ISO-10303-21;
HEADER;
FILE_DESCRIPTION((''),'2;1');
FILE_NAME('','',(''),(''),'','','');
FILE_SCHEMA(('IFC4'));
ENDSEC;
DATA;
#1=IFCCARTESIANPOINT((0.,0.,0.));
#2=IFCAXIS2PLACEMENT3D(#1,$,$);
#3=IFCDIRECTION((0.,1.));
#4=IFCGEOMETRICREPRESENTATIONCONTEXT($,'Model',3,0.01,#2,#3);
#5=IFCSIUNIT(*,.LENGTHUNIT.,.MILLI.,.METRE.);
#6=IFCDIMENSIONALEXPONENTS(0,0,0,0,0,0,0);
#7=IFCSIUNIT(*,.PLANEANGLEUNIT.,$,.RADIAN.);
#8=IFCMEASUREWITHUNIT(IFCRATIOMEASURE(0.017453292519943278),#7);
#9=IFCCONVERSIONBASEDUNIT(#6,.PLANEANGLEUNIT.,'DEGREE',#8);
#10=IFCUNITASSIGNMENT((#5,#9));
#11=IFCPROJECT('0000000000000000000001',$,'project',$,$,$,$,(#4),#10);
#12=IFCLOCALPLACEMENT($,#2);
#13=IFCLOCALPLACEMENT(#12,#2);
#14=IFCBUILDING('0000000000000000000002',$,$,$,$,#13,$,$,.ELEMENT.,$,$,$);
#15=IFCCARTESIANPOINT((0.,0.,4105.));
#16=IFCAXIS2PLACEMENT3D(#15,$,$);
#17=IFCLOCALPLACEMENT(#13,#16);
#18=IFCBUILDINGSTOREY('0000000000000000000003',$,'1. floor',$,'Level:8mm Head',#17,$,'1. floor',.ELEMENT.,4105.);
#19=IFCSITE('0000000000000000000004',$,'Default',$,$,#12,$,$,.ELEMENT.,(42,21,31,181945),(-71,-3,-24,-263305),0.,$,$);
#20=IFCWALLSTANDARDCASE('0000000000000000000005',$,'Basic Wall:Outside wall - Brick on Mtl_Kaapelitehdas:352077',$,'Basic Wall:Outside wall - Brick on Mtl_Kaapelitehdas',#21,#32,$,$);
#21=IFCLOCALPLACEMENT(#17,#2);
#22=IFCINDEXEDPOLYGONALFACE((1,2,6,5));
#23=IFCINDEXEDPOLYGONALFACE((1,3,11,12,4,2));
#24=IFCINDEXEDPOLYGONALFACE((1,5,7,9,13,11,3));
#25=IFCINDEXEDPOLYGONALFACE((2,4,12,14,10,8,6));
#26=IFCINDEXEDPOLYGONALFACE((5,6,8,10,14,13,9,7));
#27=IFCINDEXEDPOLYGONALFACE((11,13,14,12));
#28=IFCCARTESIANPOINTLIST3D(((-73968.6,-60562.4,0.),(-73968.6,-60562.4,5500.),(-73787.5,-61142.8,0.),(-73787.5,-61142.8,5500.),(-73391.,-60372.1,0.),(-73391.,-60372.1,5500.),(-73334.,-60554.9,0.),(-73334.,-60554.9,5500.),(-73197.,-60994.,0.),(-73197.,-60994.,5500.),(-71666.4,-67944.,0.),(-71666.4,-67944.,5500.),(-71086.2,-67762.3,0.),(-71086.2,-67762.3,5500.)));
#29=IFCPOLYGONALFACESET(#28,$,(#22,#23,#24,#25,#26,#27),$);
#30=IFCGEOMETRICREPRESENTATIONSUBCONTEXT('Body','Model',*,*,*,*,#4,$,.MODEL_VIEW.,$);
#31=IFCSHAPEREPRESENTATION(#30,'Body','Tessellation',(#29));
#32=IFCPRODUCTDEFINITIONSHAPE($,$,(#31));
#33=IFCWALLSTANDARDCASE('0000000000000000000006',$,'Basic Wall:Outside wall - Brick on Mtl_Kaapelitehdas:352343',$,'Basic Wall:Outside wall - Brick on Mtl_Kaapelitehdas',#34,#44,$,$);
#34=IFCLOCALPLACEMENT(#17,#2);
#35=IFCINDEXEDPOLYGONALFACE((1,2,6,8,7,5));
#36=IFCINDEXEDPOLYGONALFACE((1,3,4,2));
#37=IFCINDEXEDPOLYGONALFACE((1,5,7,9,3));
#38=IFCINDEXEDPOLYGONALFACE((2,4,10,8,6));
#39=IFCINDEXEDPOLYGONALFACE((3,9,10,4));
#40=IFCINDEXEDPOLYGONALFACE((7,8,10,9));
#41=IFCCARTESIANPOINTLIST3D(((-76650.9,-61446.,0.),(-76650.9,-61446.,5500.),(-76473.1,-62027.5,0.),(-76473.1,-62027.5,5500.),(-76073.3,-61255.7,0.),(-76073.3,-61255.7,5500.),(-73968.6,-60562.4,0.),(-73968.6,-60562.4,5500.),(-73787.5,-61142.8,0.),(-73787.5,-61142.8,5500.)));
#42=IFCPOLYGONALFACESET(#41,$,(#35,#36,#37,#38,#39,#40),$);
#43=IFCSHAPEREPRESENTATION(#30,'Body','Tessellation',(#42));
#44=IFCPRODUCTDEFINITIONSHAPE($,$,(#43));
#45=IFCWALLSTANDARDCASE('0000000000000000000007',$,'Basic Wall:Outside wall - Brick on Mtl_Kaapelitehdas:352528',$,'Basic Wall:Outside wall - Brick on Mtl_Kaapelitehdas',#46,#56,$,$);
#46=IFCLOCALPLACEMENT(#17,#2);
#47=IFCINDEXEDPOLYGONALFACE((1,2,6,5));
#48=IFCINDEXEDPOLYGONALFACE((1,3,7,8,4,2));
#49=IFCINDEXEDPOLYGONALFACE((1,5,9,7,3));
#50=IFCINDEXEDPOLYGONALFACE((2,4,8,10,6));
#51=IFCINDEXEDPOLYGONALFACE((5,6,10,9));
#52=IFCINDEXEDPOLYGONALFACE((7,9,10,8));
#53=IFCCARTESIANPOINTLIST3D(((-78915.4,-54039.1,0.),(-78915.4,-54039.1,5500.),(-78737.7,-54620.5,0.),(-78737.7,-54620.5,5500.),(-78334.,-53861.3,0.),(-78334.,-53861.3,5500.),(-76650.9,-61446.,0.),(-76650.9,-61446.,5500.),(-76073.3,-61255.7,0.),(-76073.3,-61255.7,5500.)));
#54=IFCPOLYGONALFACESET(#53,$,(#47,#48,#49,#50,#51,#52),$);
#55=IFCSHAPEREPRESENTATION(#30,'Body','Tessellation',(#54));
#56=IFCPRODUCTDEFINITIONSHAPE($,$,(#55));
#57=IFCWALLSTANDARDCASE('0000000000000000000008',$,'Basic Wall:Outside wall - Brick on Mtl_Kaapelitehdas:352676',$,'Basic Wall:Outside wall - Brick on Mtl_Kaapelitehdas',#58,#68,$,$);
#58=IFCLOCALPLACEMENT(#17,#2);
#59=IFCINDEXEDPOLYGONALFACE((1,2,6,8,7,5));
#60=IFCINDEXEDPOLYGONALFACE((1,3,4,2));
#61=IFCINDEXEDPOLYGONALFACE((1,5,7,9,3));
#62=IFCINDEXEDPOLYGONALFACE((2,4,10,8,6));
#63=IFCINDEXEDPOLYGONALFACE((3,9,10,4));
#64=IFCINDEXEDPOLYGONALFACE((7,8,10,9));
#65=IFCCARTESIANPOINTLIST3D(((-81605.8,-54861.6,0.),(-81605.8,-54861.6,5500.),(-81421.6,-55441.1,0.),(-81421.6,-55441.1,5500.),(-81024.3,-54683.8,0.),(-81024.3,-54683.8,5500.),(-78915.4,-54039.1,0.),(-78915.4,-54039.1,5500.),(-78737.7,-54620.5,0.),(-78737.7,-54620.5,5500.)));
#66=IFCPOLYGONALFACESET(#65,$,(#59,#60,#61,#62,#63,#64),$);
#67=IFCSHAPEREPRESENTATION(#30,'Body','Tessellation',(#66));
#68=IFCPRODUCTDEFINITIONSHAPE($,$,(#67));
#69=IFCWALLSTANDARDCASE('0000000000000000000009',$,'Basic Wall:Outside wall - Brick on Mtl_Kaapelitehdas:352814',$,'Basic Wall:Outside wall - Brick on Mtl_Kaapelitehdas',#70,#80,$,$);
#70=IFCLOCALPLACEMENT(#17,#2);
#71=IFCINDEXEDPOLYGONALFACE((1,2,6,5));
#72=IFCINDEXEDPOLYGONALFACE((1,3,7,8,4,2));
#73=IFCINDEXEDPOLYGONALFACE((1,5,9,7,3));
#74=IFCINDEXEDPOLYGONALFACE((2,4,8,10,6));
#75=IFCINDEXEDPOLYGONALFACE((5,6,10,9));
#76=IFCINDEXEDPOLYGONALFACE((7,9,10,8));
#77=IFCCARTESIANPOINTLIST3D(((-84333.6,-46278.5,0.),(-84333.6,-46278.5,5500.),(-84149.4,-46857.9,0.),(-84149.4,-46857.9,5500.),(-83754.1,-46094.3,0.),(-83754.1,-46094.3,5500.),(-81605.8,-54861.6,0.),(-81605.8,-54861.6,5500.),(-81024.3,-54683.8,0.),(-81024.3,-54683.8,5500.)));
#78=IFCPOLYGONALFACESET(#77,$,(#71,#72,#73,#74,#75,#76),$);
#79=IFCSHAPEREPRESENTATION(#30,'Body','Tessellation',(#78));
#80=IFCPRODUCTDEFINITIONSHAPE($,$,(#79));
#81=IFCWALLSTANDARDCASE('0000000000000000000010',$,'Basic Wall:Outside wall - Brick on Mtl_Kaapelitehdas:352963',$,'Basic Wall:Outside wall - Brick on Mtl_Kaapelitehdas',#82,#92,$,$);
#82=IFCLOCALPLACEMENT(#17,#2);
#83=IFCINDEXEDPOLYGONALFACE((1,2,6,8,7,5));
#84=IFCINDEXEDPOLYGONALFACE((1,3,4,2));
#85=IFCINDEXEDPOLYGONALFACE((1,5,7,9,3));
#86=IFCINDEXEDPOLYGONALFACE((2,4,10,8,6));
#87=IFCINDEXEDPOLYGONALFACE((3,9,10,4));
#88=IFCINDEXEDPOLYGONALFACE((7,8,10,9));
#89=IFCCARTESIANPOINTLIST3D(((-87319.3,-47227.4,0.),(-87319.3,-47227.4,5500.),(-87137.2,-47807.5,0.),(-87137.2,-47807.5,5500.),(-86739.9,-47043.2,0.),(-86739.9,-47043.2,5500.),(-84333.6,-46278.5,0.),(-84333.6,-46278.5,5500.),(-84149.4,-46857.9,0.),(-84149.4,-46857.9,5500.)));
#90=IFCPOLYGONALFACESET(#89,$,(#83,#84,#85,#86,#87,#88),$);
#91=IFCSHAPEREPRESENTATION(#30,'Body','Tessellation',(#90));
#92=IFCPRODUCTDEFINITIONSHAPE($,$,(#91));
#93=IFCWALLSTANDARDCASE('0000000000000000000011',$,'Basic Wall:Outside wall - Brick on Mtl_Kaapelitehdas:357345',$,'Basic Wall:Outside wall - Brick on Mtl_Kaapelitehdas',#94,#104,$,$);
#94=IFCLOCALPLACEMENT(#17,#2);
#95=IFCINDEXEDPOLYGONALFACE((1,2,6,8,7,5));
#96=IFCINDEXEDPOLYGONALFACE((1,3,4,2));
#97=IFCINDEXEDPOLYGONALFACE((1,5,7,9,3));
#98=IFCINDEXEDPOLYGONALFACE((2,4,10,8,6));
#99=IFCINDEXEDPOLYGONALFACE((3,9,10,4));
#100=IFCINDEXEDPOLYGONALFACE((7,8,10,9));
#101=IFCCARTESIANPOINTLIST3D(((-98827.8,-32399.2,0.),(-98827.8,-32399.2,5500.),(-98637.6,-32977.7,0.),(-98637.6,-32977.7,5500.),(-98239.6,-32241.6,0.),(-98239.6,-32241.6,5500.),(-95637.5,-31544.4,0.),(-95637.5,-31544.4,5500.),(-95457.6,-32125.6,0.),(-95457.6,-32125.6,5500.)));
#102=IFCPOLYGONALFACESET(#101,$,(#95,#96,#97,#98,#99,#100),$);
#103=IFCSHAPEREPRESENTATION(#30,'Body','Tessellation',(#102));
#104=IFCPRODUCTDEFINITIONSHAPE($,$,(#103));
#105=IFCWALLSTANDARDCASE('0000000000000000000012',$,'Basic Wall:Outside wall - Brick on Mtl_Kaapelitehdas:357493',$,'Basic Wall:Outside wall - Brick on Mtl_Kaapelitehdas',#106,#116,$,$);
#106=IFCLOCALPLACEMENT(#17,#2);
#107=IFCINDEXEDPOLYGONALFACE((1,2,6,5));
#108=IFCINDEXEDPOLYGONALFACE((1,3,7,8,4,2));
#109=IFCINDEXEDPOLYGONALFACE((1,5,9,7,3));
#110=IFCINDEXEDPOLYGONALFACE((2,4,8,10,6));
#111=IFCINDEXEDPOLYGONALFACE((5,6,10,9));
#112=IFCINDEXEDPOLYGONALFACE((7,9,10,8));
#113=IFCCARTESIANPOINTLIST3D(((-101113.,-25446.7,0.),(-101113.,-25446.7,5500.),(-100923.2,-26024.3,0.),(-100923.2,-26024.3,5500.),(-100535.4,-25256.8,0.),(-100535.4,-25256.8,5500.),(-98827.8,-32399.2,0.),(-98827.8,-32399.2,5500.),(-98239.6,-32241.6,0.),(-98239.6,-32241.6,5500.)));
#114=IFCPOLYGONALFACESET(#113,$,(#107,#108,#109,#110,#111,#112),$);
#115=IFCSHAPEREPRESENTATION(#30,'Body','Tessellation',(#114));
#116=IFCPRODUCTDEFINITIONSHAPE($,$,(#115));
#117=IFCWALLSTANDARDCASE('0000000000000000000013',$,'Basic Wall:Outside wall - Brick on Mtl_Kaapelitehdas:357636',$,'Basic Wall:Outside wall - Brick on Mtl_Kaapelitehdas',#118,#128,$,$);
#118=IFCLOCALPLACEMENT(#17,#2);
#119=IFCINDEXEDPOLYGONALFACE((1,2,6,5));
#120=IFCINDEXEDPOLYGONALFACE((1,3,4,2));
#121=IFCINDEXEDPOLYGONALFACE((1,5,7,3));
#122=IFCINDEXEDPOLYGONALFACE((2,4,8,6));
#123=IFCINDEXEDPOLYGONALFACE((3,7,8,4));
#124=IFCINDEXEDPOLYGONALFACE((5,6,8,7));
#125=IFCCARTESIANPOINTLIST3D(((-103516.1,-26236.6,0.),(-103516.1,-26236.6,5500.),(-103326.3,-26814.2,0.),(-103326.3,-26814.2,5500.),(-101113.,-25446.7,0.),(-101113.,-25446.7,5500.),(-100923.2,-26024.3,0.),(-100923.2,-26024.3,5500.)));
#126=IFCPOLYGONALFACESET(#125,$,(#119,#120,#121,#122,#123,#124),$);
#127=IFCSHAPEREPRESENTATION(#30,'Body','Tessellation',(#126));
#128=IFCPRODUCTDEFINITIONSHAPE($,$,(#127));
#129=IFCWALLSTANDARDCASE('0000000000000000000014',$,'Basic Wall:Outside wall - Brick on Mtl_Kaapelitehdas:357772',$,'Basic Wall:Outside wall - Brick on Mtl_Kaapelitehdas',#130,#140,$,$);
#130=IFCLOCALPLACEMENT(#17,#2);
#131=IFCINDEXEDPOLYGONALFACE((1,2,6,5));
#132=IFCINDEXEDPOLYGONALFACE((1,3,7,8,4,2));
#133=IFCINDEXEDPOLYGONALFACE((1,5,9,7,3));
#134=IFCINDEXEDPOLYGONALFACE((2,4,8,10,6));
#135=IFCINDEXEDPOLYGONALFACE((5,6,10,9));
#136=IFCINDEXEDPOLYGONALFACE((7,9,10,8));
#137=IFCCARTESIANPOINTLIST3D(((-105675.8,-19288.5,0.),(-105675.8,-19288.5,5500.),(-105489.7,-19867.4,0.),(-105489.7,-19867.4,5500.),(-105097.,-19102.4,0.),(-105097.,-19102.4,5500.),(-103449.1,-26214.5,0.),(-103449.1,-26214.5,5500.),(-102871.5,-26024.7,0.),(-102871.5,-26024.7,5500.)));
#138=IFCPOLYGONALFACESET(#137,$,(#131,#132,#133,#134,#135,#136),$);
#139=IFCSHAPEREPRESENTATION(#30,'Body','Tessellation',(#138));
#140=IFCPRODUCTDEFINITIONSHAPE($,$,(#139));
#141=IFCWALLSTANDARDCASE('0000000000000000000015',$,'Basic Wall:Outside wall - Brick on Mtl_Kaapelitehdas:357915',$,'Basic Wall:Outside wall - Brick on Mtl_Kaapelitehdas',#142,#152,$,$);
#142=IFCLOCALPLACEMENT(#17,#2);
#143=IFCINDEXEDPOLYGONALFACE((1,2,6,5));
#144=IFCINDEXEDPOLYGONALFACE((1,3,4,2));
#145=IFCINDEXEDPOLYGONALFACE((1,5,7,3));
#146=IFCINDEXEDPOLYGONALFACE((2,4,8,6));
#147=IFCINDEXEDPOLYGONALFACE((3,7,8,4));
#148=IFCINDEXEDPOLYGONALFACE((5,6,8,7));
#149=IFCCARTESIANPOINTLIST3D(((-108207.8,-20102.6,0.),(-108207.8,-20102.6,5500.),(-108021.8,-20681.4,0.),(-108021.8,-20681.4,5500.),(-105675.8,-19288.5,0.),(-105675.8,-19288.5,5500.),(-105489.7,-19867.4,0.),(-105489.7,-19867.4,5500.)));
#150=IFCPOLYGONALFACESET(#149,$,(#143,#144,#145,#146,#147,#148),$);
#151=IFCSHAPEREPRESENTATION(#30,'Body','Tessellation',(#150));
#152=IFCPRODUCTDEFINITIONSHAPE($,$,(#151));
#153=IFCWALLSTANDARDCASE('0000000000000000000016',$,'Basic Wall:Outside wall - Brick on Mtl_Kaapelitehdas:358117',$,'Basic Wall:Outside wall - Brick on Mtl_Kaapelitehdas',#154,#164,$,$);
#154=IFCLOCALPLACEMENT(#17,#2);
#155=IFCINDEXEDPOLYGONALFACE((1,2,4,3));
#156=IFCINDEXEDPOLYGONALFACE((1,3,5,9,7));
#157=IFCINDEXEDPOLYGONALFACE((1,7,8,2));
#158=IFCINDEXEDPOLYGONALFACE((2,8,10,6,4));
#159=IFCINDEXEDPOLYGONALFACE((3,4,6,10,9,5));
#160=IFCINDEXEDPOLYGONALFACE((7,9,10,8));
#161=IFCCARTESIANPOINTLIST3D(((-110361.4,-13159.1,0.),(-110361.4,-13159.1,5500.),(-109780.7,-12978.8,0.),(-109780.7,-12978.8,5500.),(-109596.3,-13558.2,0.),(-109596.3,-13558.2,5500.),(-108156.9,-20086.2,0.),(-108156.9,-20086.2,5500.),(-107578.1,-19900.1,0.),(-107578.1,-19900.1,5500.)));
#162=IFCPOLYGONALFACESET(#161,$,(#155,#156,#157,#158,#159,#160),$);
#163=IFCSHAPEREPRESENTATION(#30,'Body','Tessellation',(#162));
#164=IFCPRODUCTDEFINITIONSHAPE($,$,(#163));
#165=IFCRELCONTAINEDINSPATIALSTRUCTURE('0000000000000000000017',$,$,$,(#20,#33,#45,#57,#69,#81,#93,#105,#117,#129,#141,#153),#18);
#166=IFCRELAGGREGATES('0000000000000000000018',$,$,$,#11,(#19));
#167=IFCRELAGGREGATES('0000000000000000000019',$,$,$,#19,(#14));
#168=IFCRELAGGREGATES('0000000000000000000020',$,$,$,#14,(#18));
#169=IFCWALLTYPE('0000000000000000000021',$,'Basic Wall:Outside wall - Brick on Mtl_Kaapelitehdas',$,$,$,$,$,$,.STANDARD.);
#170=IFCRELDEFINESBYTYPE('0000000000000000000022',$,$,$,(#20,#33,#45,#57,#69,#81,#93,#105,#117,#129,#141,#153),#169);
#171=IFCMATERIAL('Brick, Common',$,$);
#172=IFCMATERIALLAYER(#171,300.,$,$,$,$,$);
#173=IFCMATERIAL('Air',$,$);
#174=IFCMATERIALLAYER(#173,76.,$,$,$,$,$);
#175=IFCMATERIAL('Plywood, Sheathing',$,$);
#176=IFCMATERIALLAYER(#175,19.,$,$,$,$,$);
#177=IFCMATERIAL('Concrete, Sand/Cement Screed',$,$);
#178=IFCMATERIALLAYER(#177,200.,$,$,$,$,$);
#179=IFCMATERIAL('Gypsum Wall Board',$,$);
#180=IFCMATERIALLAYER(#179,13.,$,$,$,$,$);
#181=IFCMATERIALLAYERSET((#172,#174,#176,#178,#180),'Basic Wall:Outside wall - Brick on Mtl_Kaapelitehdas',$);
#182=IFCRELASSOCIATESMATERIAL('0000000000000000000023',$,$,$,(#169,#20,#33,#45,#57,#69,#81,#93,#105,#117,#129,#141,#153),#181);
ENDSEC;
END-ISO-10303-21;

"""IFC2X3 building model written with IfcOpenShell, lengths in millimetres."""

from ifc_helpers import new_model, entity, si_unit, converted_unit, direction, frame, frame_2d, origin, place, context, subcontext, project, spatial, polyline, rectangle, outline, extrude, material, layer, layer_set, layer_usage, type_object, element, save


model = new_model("IFC2X3")

# Units and contexts
model_context = context("Model", 3, precision=0.01, world=origin(), true_north=direction((0.0, 1.0)))
body_context = subcontext(model_context, "Body", "Model", "MODEL_VIEW")
ifc_project = project(units=[si_unit("LENGTHUNIT", "METRE", prefix="MILLI"), converted_unit("PLANEANGLEUNIT", "DEGREE", entity("IfcRatioMeasure", 0.017453292519943278), si_unit("PLANEANGLEUNIT", "RADIAN"), dimensions=[0, 0, 0, 0, 0, 0, 0])], contexts=[model_context])

# Site, building, storey
site_placement = place(None, origin())
site = spatial("IfcSite", under=ifc_project, at=site_placement, Name="Default", CompositionType="ELEMENT", RefLatitude=(42, 21, 31, 181945), RefLongitude=(-71, -3, -24, -263305), RefElevation=0.0)
building_placement = place(site_placement, origin())
building = spatial("IfcBuilding", under=site, at=building_placement, CompositionType="ELEMENT")
storey_placement = place(building_placement, frame((0.0, 0.0, 4105.0)))
storey = spatial("IfcBuildingStorey", under=building, at=storey_placement, Name="1. floor", ObjectType="Level:8mm Head", LongName="1. floor", CompositionType="ELEMENT", Elevation=4105.0)

# Walls
ifc_material_1 = material(Name="Brick, Common")
ifc_layer_1 = layer(ifc_material_1, 300.0)
ifc_material_2 = material(Name="Air")
ifc_layer_2 = layer(ifc_material_2, 76.0)
ifc_material_3 = material(Name="Plywood, Sheathing")
ifc_layer_3 = layer(ifc_material_3, 19.0)
ifc_material_4 = material(Name="Concrete, Sand/Cement Screed")
ifc_layer_4 = layer(ifc_material_4, 200.0)
ifc_material_5 = material(Name="Gypsum Wall Board")
ifc_layer_5 = layer(ifc_material_5, 13.0)
ifc_layer_set_1 = layer_set([ifc_layer_1, ifc_layer_2, ifc_layer_3, ifc_layer_4, ifc_layer_5], Name="Basic Wall:Outside wall - Brick on Mtl_Kaapelitehdas")
ifc_layer_usage_1 = layer_usage(ifc_layer_set_1, "AXIS2", "NEGATIVE", 304.0)
wall_type_1 = type_object("IfcWallType", Name="Basic Wall:Outside wall - Brick on Mtl_Kaapelitehdas", PredefinedType="STANDARD", material=ifc_layer_set_1)
wall_1_placement = place(storey_placement, frame((-71376.1, -67853.5, 0.0), z_axis=(0.0, 0.0, 1.0), x_axis=(-0.297735, 0.954648, 0.0)))
element("IfcWallStandardCase", 1, at=wall_1_placement, inside=storey, type_object=wall_type_1, material=ifc_layer_usage_1, Name="Basic Wall:Outside wall - Brick on Mtl_Kaapelitehdas:352077", ObjectType="Basic Wall:Outside wall - Brick on Mtl_Kaapelitehdas", context=body_context, shape_type="SweptSolid", body=[
    extrude(outline(polyline([(7742.0, -304.0), (7732.3, 304.0), (7124.3, 304.0), (0.0, 304.0), (0.8, -304.0), (7090.5, -304.0), (7550.5, -304.0), (7742.0, -304.0)])), origin(), (0.0, 0.0, 1.0), 5500.0),
])
ifc_layer_usage_2 = layer_usage(ifc_layer_set_1, "AXIS2", "NEGATIVE", 304.0)
wall_2_placement = place(storey_placement, frame((-73873.4, -60851.1, 0.0), z_axis=(0.0, 0.0, 1.0), x_axis=(-0.949794, -0.312877, 0.0)))
element("IfcWallStandardCase", 2, at=wall_2_placement, inside=storey, type_object=wall_type_1, material=ifc_layer_usage_2, Name="Basic Wall:Outside wall - Brick on Mtl_Kaapelitehdas:352343", ObjectType="Basic Wall:Outside wall - Brick on Mtl_Kaapelitehdas", context=body_context, shape_type="SweptSolid", body=[
    extrude(outline(polyline([(2824.1, -304.0), (2837.2, 304.0), (9.7, 304.0), (0.0, -304.0), (2216.0, -304.0), (2824.1, -304.0)])), origin(), (0.0, 0.0, 1.0), 5500.0),
])
ifc_layer_usage_3 = layer_usage(ifc_layer_set_1, "AXIS2", "NEGATIVE", 304.0)
wall_3_placement = place(storey_placement, frame((-76360.2, -61357.1, 0.0), z_axis=(0.0, 0.0, 1.0), x_axis=(-0.292372, 0.956305, 0.0)))
element("IfcWallStandardCase", 3, at=wall_3_placement, inside=storey, type_object=wall_type_1, material=ifc_layer_usage_3, Name="Basic Wall:Outside wall - Brick on Mtl_Kaapelitehdas:352528", ObjectType="Basic Wall:Outside wall - Brick on Mtl_Kaapelitehdas", context=body_context, shape_type="SweptSolid", body=[
    extrude(outline(polyline([(7745.3, -304.0), (7745.3, 304.0), (7137.3, 304.0), (0.0, 304.0), (13.1, -304.0), (7745.3, -304.0)])), origin(), (0.0, 0.0, 1.0), 5500.0),
])
ifc_layer_usage_4 = layer_usage(ifc_layer_set_1, "AXIS2", "NEGATIVE", 304.0)
wall_4_placement = place(storey_placement, frame((-78826.5, -54329.8, 0.0), z_axis=(0.0, 0.0, 1.0), x_axis=(-0.956305, -0.292372, 0.0)))
element("IfcWallStandardCase", 4, at=wall_4_placement, inside=storey, type_object=wall_type_1, material=ifc_layer_usage_4, Name="Basic Wall:Outside wall - Brick on Mtl_Kaapelitehdas:352676", ObjectType="Basic Wall:Outside wall - Brick on Mtl_Kaapelitehdas", context=body_context, shape_type="SweptSolid", body=[
    extrude(outline(polyline([(2813.3, -304.0), (2806.6, 304.0), (0.0, 304.0), (0.0, -304.0), (2205.2, -304.0), (2813.3, -304.0)])), origin(), (0.0, 0.0, 1.0), 5500.0),
])
ifc_layer_usage_5 = layer_usage(ifc_layer_set_1, "AXIS2", "NEGATIVE", 304.0)
wall_5_placement = place(storey_placement, frame((-81314.0, -54775.9, 0.0), z_axis=(0.0, 0.0, 1.0), x_axis=(-0.302882, 0.953028, 0.0)))
element("IfcWallStandardCase", 5, at=wall_5_placement, inside=storey, type_object=wall_type_1, material=ifc_layer_usage_5, Name="Basic Wall:Outside wall - Brick on Mtl_Kaapelitehdas:352814", ObjectType="Basic Wall:Outside wall - Brick on Mtl_Kaapelitehdas", context=body_context, shape_type="SweptSolid", body=[
    extrude(outline(polyline([(9012.8, -304.0), (9012.8, 304.0), (8404.8, 304.0), (6.7, 304.0), (0.0, -304.0), (9012.8, -304.0)])), origin(), (0.0, 0.0, 1.0), 5500.0),
])
ifc_layer_usage_6 = layer_usage(ifc_layer_set_1, "AXIS2", "NEGATIVE", 304.0)
wall_6_placement = place(storey_placement, frame((-84241.5, -46568.2, 0.0), z_axis=(0.0, 0.0, 1.0), x_axis=(-0.953028, -0.302882, 0.0)))
element("IfcWallStandardCase", 6, at=wall_6_placement, inside=storey, type_object=wall_type_1, material=ifc_layer_usage_6, Name="Basic Wall:Outside wall - Brick on Mtl_Kaapelitehdas:352963", ObjectType="Basic Wall:Outside wall - Brick on Mtl_Kaapelitehdas", context=body_context, shape_type="SweptSolid", body=[
    extrude(outline(polyline([(3132.9, -304.0), (3135.1, 304.0), (0.0, 304.0), (0.0, -304.0), (2524.9, -304.0), (3132.9, -304.0)])), origin(), (0.0, 0.0, 1.0), 5500.0),
])
ifc_layer_usage_7 = layer_usage(ifc_layer_set_1, "AXIS2", "NEGATIVE", 304.0)
wall_7_placement = place(storey_placement, frame((-95536.3, -31832.0, 0.0), z_axis=(0.0, 0.0, 1.0), x_axis=(-0.965926, -0.258819, 0.0)))
element("IfcWallStandardCase", 7, at=wall_7_placement, inside=storey, type_object=wall_type_1, material=ifc_layer_usage_7, Name="Basic Wall:Outside wall - Brick on Mtl_Kaapelitehdas:357345", ObjectType="Basic Wall:Outside wall - Brick on Mtl_Kaapelitehdas", context=body_context, shape_type="SweptSolid", body=[
    extrude(outline(polyline([(3326.1, -304.0), (3292.2, 304.0), (0.0, 304.0), (23.3, -304.0), (2717.2, -304.0), (3326.1, -304.0)])), origin(), (0.0, 0.0, 1.0), 5500.0),
])
ifc_layer_usage_8 = layer_usage(ifc_layer_set_1, "AXIS2", "NEGATIVE", 304.0)
wall_8_placement = place(storey_placement, frame((-98528.4, -32336.5, 0.0), z_axis=(0.0, 0.0, 1.0), x_axis=(-0.312256, 0.949998, 0.0)))
element("IfcWallStandardCase", 8, at=wall_8_placement, inside=storey, type_object=wall_type_1, material=ifc_layer_usage_8, Name="Basic Wall:Outside wall - Brick on Mtl_Kaapelitehdas:357493", ObjectType="Basic Wall:Outside wall - Brick on Mtl_Kaapelitehdas", context=body_context, shape_type="SweptSolid", body=[
    extrude(outline(polyline([(7352.4, -304.0), (7352.4, 304.0), (6744.4, 304.0), (33.9, 304.0), (0.0, -304.0), (7352.4, -304.0)])), origin(), (0.0, 0.0, 1.0), 5500.0),
])
ifc_layer_usage_9 = layer_usage(ifc_layer_set_1, "AXIS2", "NEGATIVE", 304.0)
wall_9_placement = place(storey_placement, frame((-101018.1, -25735.5, 0.0), z_axis=(0.0, 0.0, 1.0), x_axis=(-0.949998, -0.312256, 0.0)))
element("IfcWallStandardCase", 9, at=wall_9_placement, inside=storey, type_object=wall_type_1, material=ifc_layer_usage_9, Name="Basic Wall:Outside wall - Brick on Mtl_Kaapelitehdas:357636", ObjectType="Basic Wall:Outside wall - Brick on Mtl_Kaapelitehdas", context=body_context, shape_type="SweptSolid", body=[
    extrude(rectangle(XDim=2529.6, YDim=608.0, at=frame_2d((1264.8, 0.0), x_axis=(-1.0, 0.0))), origin(), (0.0, 0.0, 1.0), 5500.0),
])
ifc_layer_usage_10 = layer_usage(ifc_layer_set_1, "AXIS2", "NEGATIVE", 304.0)
wall_10_placement = place(storey_placement, frame((-103159.7, -26121.5, 0.0), z_axis=(0.0, 0.0, 1.0), x_axis=(-0.306077, 0.952007, 0.0)))
element("IfcWallStandardCase", 10, at=wall_10_placement, inside=storey, type_object=wall_type_1, material=ifc_layer_usage_10, Name="Basic Wall:Outside wall - Brick on Mtl_Kaapelitehdas:357772", ObjectType="Basic Wall:Outside wall - Brick on Mtl_Kaapelitehdas", context=body_context, shape_type="SweptSolid", body=[
    extrude(outline(polyline([(7275.1, -304.0), (7275.1, 304.0), (6667.1, 304.0), (0.0, 304.0), (4.0, -304.0), (7275.1, -304.0)])), origin(), (0.0, 0.0, 1.0), 5500.0),
])
ifc_layer_usage_11 = layer_usage(ifc_layer_set_1, "AXIS2", "NEGATIVE", 304.0)
wall_11_placement = place(storey_placement, frame((-105582.8, -19577.9, 0.0), z_axis=(0.0, 0.0, 1.0), x_axis=(-0.952007, -0.306077, 0.0)))
element("IfcWallStandardCase", 11, at=wall_11_placement, inside=storey, type_object=wall_type_1, material=ifc_layer_usage_11, Name="Basic Wall:Outside wall - Brick on Mtl_Kaapelitehdas:357915", ObjectType="Basic Wall:Outside wall - Brick on Mtl_Kaapelitehdas", context=body_context, shape_type="SweptSolid", body=[
    extrude(rectangle(XDim=2659.7, YDim=608.0, at=frame_2d((1329.8, 0.0), x_axis=(-1.0, 0.0))), origin(), (0.0, 0.0, 1.0), 5500.0),
])
ifc_layer_usage_12 = layer_usage(ifc_layer_set_1, "AXIS2", "NEGATIVE", 304.0)
wall_12_placement = place(storey_placement, frame((-107867.2, -19994.0, 0.0), z_axis=(0.0, 0.0, 1.0), x_axis=(-0.303248, 0.952912, 0.0)))
element("IfcWallStandardCase", 12, at=wall_12_placement, inside=storey, type_object=wall_type_1, material=ifc_layer_usage_12, Name="Basic Wall:Outside wall - Brick on Mtl_Kaapelitehdas:358117", ObjectType="Basic Wall:Outside wall - Brick on Mtl_Kaapelitehdas", context=body_context, shape_type="SweptSolid", body=[
    extrude(outline(polyline([(7265.1, -304.0), (7269.5, 304.0), (0.0, 304.0), (1.8, -304.0), (6657.1, -304.0), (7265.1, -304.0)])), origin(), (0.0, 0.0, 1.0), 5500.0),
])

save(model, "model.ifc")
